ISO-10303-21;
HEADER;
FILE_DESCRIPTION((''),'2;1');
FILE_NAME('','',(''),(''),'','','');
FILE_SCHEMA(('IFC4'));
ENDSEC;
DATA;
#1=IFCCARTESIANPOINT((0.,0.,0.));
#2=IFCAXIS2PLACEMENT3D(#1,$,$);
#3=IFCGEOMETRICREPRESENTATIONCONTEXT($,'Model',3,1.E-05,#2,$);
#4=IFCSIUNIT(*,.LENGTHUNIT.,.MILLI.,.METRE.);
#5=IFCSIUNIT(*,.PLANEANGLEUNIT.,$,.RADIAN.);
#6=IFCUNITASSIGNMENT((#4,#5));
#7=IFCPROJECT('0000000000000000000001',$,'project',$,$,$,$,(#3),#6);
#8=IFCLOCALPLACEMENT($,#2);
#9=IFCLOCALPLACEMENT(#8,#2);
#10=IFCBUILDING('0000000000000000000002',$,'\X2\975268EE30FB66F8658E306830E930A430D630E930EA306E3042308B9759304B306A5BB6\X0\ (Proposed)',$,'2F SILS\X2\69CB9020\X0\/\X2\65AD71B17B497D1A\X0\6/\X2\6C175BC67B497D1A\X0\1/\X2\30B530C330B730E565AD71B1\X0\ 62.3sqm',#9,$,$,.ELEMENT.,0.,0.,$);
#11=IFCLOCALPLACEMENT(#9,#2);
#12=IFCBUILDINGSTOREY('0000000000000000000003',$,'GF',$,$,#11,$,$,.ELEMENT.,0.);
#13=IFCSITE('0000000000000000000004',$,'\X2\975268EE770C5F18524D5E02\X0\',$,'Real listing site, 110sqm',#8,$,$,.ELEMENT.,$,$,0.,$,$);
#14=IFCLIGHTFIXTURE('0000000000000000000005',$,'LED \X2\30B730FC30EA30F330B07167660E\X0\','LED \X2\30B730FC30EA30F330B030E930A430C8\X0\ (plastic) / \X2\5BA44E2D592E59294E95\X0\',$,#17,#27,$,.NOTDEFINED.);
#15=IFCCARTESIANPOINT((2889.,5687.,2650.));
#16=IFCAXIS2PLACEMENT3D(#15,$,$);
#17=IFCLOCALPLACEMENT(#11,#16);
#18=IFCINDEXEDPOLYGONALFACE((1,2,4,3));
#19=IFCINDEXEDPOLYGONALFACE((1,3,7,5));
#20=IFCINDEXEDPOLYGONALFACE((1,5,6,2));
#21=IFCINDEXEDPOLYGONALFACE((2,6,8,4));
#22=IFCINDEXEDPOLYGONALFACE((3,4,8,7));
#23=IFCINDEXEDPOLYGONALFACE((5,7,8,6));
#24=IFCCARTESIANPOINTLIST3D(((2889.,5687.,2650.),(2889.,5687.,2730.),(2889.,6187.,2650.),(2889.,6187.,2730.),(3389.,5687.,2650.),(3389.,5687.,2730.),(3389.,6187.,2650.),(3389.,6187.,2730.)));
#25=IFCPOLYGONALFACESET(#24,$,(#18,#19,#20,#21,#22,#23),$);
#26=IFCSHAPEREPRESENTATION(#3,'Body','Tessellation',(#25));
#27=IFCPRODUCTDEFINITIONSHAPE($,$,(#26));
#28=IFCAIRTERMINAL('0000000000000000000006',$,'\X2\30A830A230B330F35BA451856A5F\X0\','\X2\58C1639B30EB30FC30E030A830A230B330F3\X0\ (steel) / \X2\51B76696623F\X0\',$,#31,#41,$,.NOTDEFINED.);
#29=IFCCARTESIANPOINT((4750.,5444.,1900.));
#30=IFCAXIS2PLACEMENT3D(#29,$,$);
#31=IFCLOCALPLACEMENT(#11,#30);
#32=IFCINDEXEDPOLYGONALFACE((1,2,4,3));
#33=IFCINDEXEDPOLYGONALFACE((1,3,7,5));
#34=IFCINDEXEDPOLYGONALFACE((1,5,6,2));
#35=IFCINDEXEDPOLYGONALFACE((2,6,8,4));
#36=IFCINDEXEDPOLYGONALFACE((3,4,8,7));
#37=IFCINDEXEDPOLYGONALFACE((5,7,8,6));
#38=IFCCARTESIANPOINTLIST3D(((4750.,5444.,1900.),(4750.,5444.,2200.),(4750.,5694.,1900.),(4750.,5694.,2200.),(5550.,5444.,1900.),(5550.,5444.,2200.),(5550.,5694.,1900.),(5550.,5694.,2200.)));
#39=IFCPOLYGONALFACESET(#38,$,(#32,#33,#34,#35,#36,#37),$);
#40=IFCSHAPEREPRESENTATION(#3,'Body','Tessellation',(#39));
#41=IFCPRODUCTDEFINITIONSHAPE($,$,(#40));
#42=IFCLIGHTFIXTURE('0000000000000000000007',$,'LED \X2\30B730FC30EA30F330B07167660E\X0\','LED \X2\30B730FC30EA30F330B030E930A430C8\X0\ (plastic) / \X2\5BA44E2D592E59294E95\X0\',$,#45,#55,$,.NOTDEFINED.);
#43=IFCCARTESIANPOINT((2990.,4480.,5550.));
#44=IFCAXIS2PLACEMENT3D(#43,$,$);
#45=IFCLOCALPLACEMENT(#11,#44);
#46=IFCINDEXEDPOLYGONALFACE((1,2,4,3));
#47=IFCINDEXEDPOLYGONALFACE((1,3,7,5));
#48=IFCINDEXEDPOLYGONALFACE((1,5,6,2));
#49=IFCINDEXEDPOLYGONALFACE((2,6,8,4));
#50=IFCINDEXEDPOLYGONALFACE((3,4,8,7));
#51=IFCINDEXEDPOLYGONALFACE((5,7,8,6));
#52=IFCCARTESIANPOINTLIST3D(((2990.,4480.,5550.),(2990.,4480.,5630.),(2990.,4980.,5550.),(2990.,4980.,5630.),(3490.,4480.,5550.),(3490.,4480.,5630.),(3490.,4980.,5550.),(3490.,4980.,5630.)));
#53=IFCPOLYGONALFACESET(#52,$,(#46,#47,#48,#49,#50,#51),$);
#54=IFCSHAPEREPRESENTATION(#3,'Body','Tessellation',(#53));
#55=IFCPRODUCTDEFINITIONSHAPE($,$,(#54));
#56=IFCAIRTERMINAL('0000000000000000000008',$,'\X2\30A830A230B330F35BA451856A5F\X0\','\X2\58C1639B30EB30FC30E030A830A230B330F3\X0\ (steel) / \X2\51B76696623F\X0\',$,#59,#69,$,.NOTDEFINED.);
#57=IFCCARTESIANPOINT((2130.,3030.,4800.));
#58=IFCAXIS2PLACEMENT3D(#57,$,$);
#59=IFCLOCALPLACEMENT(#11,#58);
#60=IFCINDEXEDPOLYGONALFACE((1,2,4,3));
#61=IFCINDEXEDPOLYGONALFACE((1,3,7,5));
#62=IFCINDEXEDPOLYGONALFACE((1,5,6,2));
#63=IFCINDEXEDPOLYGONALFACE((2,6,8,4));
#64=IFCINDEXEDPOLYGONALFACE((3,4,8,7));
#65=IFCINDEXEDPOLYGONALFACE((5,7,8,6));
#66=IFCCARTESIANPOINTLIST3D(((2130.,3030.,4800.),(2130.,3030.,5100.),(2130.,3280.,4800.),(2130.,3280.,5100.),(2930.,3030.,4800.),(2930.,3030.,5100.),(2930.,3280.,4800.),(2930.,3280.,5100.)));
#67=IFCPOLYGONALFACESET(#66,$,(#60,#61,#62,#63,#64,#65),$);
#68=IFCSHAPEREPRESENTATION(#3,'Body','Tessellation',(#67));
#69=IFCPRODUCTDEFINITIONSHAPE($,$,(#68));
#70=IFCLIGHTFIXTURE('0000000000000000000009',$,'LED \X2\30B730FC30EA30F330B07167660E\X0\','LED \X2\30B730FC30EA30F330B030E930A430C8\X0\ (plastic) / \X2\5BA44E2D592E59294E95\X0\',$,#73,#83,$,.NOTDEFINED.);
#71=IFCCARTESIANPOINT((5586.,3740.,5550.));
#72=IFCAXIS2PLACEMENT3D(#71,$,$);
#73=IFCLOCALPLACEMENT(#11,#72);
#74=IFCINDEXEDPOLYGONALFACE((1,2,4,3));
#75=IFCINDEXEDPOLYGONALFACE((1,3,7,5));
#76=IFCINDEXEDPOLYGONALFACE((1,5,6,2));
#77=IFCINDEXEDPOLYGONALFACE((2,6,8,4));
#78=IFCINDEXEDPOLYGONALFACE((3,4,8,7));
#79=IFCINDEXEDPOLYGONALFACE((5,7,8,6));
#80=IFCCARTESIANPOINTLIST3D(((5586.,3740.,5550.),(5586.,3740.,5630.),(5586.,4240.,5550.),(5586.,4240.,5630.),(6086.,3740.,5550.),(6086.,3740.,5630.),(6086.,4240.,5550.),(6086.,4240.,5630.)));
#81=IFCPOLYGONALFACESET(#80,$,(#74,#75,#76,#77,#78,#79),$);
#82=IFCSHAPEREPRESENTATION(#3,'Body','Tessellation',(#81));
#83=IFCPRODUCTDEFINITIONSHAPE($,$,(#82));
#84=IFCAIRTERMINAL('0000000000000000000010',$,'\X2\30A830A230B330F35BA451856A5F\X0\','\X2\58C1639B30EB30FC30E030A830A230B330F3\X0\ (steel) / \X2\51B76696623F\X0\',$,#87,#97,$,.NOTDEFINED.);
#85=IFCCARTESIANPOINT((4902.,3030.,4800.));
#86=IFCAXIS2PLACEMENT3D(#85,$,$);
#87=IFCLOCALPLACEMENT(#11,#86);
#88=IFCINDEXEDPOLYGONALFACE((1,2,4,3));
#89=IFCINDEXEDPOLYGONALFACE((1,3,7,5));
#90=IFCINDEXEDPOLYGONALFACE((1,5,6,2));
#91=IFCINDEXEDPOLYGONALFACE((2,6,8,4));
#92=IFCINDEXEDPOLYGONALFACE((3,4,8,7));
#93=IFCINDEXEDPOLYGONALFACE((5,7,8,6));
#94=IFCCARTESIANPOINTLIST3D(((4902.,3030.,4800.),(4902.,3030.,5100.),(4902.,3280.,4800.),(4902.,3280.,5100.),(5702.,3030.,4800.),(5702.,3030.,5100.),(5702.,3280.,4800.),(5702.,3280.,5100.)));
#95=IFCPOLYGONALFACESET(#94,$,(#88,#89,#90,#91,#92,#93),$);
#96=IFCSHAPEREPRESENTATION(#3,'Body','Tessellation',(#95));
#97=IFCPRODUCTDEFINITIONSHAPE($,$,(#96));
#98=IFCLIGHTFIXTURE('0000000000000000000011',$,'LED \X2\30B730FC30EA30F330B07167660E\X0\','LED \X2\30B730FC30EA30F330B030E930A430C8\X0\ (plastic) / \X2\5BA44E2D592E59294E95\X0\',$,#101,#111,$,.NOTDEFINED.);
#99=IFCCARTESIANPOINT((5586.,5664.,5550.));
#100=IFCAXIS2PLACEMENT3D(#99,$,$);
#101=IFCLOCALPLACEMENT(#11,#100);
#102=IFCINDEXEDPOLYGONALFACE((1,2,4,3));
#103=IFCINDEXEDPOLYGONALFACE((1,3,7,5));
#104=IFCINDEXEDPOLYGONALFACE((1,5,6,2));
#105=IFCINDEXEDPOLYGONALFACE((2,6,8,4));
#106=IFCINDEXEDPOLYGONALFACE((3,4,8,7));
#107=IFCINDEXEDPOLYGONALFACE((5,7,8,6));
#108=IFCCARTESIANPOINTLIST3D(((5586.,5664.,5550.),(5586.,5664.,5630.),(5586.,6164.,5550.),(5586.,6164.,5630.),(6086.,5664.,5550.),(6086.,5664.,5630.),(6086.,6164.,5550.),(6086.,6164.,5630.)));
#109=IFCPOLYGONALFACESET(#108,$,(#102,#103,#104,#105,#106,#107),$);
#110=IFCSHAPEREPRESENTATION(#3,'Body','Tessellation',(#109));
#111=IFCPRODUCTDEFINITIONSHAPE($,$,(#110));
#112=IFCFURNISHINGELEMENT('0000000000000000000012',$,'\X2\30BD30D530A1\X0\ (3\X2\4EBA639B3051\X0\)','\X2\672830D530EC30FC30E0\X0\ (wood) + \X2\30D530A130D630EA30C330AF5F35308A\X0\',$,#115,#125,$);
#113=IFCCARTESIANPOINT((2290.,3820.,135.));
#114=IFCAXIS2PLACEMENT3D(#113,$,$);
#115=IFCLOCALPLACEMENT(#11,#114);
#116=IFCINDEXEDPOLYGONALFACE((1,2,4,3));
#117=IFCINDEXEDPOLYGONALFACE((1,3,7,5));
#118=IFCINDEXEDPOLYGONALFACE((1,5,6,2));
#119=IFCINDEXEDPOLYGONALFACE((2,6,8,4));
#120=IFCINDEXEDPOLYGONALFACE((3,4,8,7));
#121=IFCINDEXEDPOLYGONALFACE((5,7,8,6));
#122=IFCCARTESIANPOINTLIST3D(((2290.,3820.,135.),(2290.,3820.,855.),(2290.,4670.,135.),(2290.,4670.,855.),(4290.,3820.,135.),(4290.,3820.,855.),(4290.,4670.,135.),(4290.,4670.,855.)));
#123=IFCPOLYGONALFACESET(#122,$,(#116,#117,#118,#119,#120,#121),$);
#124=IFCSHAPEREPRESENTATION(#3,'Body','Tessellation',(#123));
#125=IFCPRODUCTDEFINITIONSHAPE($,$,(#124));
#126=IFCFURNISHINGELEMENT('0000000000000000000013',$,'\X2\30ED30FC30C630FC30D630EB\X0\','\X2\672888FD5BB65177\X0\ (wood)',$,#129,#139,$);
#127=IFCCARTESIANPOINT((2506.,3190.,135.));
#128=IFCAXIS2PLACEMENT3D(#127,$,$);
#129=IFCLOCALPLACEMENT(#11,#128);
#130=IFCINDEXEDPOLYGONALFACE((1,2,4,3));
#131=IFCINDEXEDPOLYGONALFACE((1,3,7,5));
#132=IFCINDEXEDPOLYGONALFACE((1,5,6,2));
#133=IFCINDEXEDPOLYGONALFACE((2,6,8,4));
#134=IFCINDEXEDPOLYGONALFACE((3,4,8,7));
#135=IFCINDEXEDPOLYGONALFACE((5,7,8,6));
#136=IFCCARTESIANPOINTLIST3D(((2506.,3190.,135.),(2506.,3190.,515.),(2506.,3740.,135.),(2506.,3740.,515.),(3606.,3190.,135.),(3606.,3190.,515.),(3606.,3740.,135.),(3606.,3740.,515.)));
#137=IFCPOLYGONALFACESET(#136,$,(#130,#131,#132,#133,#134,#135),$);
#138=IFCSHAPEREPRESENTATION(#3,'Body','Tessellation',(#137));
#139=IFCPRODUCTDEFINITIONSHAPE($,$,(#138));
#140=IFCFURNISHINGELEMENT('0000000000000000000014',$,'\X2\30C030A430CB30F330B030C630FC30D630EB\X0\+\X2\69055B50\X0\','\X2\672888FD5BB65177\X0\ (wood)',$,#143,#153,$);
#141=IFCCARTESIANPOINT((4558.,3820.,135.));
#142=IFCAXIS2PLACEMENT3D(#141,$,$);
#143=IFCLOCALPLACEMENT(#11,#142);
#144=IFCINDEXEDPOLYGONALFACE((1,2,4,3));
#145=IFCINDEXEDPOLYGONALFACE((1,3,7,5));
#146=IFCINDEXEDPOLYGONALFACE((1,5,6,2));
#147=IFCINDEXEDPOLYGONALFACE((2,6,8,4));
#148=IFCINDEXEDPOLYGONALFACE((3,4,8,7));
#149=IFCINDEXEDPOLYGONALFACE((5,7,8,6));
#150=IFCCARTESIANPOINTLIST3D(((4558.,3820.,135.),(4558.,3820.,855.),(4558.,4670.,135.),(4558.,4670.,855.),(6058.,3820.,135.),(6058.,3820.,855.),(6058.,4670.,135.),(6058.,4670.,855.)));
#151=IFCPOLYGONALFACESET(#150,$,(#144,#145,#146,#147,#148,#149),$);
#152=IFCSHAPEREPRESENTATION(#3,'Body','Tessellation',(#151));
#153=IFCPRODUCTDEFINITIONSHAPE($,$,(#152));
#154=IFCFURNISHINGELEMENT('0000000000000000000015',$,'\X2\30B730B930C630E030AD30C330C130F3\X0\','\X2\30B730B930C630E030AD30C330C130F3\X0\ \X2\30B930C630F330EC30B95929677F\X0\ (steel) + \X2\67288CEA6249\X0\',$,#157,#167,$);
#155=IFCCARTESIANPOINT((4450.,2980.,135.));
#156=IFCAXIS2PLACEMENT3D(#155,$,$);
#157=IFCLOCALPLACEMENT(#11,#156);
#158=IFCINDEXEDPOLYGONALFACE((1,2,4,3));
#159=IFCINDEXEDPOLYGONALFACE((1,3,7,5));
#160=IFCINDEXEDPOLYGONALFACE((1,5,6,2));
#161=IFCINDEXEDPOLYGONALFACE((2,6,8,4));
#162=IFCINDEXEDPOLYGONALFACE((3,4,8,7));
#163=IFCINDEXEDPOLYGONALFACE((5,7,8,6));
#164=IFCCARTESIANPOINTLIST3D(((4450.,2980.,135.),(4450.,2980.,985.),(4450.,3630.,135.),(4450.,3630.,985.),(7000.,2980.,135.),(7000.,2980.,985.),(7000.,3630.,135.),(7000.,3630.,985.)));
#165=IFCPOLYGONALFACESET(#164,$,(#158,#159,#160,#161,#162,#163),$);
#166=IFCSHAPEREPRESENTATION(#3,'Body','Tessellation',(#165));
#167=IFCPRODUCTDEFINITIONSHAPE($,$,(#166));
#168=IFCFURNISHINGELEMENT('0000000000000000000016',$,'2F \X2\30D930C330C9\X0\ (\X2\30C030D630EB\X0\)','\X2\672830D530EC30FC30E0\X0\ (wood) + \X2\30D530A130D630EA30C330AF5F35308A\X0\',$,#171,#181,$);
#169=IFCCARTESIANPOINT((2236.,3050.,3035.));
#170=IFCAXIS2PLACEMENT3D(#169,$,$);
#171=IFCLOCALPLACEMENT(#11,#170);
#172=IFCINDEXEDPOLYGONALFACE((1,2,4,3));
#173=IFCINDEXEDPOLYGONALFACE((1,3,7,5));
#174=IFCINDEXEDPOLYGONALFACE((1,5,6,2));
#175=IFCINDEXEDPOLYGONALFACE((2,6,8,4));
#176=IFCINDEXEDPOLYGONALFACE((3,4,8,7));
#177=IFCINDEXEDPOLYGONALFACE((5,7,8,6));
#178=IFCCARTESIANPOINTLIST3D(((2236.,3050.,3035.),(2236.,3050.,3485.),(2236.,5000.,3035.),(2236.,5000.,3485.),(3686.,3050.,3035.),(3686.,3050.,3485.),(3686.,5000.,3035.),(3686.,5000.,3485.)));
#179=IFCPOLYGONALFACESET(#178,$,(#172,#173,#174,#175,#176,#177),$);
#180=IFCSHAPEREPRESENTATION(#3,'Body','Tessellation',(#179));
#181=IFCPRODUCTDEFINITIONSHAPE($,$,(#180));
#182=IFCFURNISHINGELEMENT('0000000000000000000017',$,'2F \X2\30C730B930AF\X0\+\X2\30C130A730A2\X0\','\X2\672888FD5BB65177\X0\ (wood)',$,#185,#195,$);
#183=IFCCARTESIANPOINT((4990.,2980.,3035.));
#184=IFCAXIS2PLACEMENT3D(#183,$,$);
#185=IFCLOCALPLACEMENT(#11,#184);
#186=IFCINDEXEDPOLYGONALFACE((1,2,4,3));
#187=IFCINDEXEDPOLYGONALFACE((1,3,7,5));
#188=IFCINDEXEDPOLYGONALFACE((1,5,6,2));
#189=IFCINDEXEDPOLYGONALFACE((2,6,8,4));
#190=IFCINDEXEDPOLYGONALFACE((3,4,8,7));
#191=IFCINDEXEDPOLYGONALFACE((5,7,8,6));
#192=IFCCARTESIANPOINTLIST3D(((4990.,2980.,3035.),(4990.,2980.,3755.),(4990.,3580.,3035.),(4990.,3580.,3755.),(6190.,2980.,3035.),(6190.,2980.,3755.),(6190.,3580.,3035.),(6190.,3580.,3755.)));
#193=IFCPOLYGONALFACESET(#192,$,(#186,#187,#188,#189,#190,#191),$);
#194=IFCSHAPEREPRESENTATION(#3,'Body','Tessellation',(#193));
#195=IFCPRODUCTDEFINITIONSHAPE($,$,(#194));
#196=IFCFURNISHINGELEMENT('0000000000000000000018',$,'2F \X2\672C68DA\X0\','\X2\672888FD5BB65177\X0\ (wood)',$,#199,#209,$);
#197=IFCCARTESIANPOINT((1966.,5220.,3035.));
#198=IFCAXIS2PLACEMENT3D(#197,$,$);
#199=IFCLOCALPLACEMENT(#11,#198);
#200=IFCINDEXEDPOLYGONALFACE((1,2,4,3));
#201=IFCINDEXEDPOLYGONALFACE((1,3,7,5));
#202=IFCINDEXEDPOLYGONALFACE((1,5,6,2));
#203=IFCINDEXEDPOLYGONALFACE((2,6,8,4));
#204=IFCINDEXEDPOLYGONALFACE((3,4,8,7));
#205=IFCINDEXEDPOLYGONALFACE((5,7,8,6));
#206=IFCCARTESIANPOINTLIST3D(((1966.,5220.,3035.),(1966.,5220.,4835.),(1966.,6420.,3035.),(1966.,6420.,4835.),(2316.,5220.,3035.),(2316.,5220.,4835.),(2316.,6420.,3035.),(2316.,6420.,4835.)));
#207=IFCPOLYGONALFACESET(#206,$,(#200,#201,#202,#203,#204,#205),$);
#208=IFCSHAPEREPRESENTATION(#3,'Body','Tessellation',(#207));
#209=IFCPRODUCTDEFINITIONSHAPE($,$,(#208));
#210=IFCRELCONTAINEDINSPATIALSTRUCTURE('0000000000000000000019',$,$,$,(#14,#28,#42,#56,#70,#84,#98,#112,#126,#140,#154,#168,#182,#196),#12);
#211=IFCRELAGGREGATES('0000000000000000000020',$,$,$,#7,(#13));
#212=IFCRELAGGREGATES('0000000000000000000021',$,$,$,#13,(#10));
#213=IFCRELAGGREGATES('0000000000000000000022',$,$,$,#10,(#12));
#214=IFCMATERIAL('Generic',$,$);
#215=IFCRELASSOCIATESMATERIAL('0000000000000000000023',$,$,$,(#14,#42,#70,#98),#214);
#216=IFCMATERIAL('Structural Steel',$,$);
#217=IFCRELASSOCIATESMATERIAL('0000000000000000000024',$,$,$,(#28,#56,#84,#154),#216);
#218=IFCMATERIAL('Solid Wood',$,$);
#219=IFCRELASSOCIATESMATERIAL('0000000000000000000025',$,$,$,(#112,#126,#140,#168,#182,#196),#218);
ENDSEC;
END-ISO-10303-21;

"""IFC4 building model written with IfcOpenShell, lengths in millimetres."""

from ifc_helpers import new_model, si_unit, frame, frame_2d, origin, place, context, project, spatial, rectangle, extrude, material, element, save


model = new_model("IFC4")

# Units and contexts
model_context = context("Model", 3, precision=1e-05, world=origin())
ifc_project = project(units=[si_unit("LENGTHUNIT", "METRE", prefix="MILLI"), si_unit("PLANEANGLEUNIT", "RADIAN")], contexts=[model_context])

# Site, building, storey
site_placement = place(None, origin())
site = spatial("IfcSite", under=ifc_project, at=site_placement, Name="青森県弘前市", ObjectType="Real listing site, 110sqm", CompositionType="ELEMENT", RefElevation=0.0)
building_placement = place(site_placement, origin())
building = spatial("IfcBuilding", under=site, at=building_placement, Name="青森・書斎とライブラリのある静かな家 (Proposed)", ObjectType="2F SILS構造/断熱等級6/気密等級1/サッシュ断熱 62.3sqm", CompositionType="ELEMENT", ElevationOfRefHeight=0.0, ElevationOfTerrain=0.0)
storey_placement = place(building_placement, origin())
storey = spatial("IfcBuildingStorey", under=building, at=storey_placement, Name="GF", CompositionType="ELEMENT", Elevation=0.0)

# Shared definitions
ifc_material_1 = material(Name="Solid Wood")

# Shared definitions
ifc_material_2 = material(Name="Structural Steel")

# Shared definitions
ifc_material_3 = material(Name="Generic")

# Light fixture
light_fixture_1_placement = place(storey_placement, frame((2889.0, 5687.0, 2650.0)))
element("IfcLightFixture", 1, at=light_fixture_1_placement, inside=storey, material=ifc_material_3, Name="LED シーリング照明", Description="LED シーリングライト (plastic) / 室中央天井", PredefinedType="NOTDEFINED", context=model_context, shape_type="SweptSolid", body=[
    extrude(rectangle(XDim=500.0, YDim=500.0, at=frame_2d((250.0, 250.0))), frame((2889.0, 5687.0, 2650.0)), (0.0, 0.0, 1.0), 80.0),
])

# Air terminal
air_terminal_1_placement = place(storey_placement, frame((4750.0, 5444.0, 1900.0)))
element("IfcAirTerminal", 2, at=air_terminal_1_placement, inside=storey, material=ifc_material_2, Name="エアコン室内機", Description="壁掛ルームエアコン (steel) / 冷暖房", PredefinedType="NOTDEFINED", context=model_context, shape_type="SweptSolid", body=[
    extrude(rectangle(XDim=800.0, YDim=250.0, at=frame_2d((400.0, 125.0))), frame((4750.0, 5444.0, 1900.0)), (0.0, 0.0, 1.0), 300.0),
])

# Light fixture
light_fixture_2_placement = place(storey_placement, frame((2990.0, 4480.0, 5550.0)))
element("IfcLightFixture", 3, at=light_fixture_2_placement, inside=storey, material=ifc_material_3, Name="LED シーリング照明", Description="LED シーリングライト (plastic) / 室中央天井", PredefinedType="NOTDEFINED", context=model_context, shape_type="SweptSolid", body=[
    extrude(rectangle(XDim=500.0, YDim=500.0, at=frame_2d((250.0, 250.0))), frame((2990.0, 4480.0, 5550.0)), (0.0, 0.0, 1.0), 80.0),
])

# Air terminal
air_terminal_2_placement = place(storey_placement, frame((2130.0, 3030.0, 4800.0)))
element("IfcAirTerminal", 4, at=air_terminal_2_placement, inside=storey, material=ifc_material_2, Name="エアコン室内機", Description="壁掛ルームエアコン (steel) / 冷暖房", PredefinedType="NOTDEFINED", context=model_context, shape_type="SweptSolid", body=[
    extrude(rectangle(XDim=800.0, YDim=250.0, at=frame_2d((400.0, 125.0))), frame((2130.0, 3030.0, 4800.0)), (0.0, 0.0, 1.0), 300.0),
])

# Light fixture
light_fixture_3_placement = place(storey_placement, frame((5586.0, 3740.0, 5550.0)))
element("IfcLightFixture", 5, at=light_fixture_3_placement, inside=storey, material=ifc_material_3, Name="LED シーリング照明", Description="LED シーリングライト (plastic) / 室中央天井", PredefinedType="NOTDEFINED", context=model_context, shape_type="SweptSolid", body=[
    extrude(rectangle(XDim=500.0, YDim=500.0, at=frame_2d((250.0, 250.0))), frame((5586.0, 3740.0, 5550.0)), (0.0, 0.0, 1.0), 80.0),
])

# Air terminal
air_terminal_3_placement = place(storey_placement, frame((4902.0, 3030.0, 4800.0)))
element("IfcAirTerminal", 6, at=air_terminal_3_placement, inside=storey, material=ifc_material_2, Name="エアコン室内機", Description="壁掛ルームエアコン (steel) / 冷暖房", PredefinedType="NOTDEFINED", context=model_context, shape_type="SweptSolid", body=[
    extrude(rectangle(XDim=800.0, YDim=250.0, at=frame_2d((400.0, 125.0))), frame((4902.0, 3030.0, 4800.0)), (0.0, 0.0, 1.0), 300.0),
])

# Light fixture
light_fixture_4_placement = place(storey_placement, frame((5586.0, 5664.0, 5550.0)))
element("IfcLightFixture", 7, at=light_fixture_4_placement, inside=storey, material=ifc_material_3, Name="LED シーリング照明", Description="LED シーリングライト (plastic) / 室中央天井", PredefinedType="NOTDEFINED", context=model_context, shape_type="SweptSolid", body=[
    extrude(rectangle(XDim=500.0, YDim=500.0, at=frame_2d((250.0, 250.0))), frame((5586.0, 5664.0, 5550.0)), (0.0, 0.0, 1.0), 80.0),
])

# Furnishing elements
furnishing_1_placement = place(storey_placement, frame((2290.0, 3820.0, 135.0)))
element("IfcFurnishingElement", 8, at=furnishing_1_placement, inside=storey, material=ifc_material_1, Name="ソファ (3人掛け)", Description="木フレーム (wood) + ファブリック張り", context=model_context, shape_type="SweptSolid", body=[
    extrude(rectangle(XDim=2000.0, YDim=850.0, at=frame_2d((1000.0, 425.0))), frame((2290.0, 3820.0, 135.0)), (0.0, 0.0, 1.0), 720.0),
])
furnishing_2_placement = place(storey_placement, frame((2506.0, 3190.0, 135.0)))
element("IfcFurnishingElement", 9, at=furnishing_2_placement, inside=storey, material=ifc_material_1, Name="ローテーブル", Description="木製家具 (wood)", context=model_context, shape_type="SweptSolid", body=[
    extrude(rectangle(XDim=1100.0, YDim=550.0, at=frame_2d((550.0, 275.0))), frame((2506.0, 3190.0, 135.0)), (0.0, 0.0, 1.0), 380.0),
])
furnishing_3_placement = place(storey_placement, frame((4558.0, 3820.0, 135.0)))
element("IfcFurnishingElement", 10, at=furnishing_3_placement, inside=storey, material=ifc_material_1, Name="ダイニングテーブル+椅子", Description="木製家具 (wood)", context=model_context, shape_type="SweptSolid", body=[
    extrude(rectangle(XDim=1500.0, YDim=850.0, at=frame_2d((750.0, 425.0))), frame((4558.0, 3820.0, 135.0)), (0.0, 0.0, 1.0), 720.0),
])
furnishing_4_placement = place(storey_placement, frame((4450.0, 2980.0, 135.0)))
element("IfcFurnishingElement", 11, at=furnishing_4_placement, inside=storey, material=ifc_material_2, Name="システムキッチン", Description="システムキッチン ステンレス天板 (steel) + 木質扉", context=model_context, shape_type="SweptSolid", body=[
    extrude(rectangle(XDim=2550.0, YDim=650.0, at=frame_2d((1275.0, 325.0))), frame((4450.0, 2980.0, 135.0)), (0.0, 0.0, 1.0), 850.0),
])
furnishing_5_placement = place(storey_placement, frame((2236.0, 3050.0, 3035.0)))
element("IfcFurnishingElement", 12, at=furnishing_5_placement, inside=storey, material=ifc_material_1, Name="2F ベッド (ダブル)", Description="木フレーム (wood) + ファブリック張り", context=model_context, shape_type="SweptSolid", body=[
    extrude(rectangle(XDim=1450.0, YDim=1950.0, at=frame_2d((725.0, 975.0))), frame((2236.0, 3050.0, 3035.0)), (0.0, 0.0, 1.0), 450.0),
])
furnishing_6_placement = place(storey_placement, frame((4990.0, 2980.0, 3035.0)))
element("IfcFurnishingElement", 13, at=furnishing_6_placement, inside=storey, material=ifc_material_1, Name="2F デスク+チェア", Description="木製家具 (wood)", context=model_context, shape_type="SweptSolid", body=[
    extrude(rectangle(XDim=1200.0, YDim=600.0, at=frame_2d((600.0, 300.0))), frame((4990.0, 2980.0, 3035.0)), (0.0, 0.0, 1.0), 720.0),
])
furnishing_7_placement = place(storey_placement, frame((1966.0, 5220.0, 3035.0)))
element("IfcFurnishingElement", 14, at=furnishing_7_placement, inside=storey, material=ifc_material_1, Name="2F 本棚", Description="木製家具 (wood)", context=model_context, shape_type="SweptSolid", body=[
    extrude(rectangle(XDim=350.0, YDim=1200.0, at=frame_2d((175.0, 600.0))), frame((1966.0, 5220.0, 3035.0)), (0.0, 0.0, 1.0), 1800.0),
])

save(model, "model.ifc")
